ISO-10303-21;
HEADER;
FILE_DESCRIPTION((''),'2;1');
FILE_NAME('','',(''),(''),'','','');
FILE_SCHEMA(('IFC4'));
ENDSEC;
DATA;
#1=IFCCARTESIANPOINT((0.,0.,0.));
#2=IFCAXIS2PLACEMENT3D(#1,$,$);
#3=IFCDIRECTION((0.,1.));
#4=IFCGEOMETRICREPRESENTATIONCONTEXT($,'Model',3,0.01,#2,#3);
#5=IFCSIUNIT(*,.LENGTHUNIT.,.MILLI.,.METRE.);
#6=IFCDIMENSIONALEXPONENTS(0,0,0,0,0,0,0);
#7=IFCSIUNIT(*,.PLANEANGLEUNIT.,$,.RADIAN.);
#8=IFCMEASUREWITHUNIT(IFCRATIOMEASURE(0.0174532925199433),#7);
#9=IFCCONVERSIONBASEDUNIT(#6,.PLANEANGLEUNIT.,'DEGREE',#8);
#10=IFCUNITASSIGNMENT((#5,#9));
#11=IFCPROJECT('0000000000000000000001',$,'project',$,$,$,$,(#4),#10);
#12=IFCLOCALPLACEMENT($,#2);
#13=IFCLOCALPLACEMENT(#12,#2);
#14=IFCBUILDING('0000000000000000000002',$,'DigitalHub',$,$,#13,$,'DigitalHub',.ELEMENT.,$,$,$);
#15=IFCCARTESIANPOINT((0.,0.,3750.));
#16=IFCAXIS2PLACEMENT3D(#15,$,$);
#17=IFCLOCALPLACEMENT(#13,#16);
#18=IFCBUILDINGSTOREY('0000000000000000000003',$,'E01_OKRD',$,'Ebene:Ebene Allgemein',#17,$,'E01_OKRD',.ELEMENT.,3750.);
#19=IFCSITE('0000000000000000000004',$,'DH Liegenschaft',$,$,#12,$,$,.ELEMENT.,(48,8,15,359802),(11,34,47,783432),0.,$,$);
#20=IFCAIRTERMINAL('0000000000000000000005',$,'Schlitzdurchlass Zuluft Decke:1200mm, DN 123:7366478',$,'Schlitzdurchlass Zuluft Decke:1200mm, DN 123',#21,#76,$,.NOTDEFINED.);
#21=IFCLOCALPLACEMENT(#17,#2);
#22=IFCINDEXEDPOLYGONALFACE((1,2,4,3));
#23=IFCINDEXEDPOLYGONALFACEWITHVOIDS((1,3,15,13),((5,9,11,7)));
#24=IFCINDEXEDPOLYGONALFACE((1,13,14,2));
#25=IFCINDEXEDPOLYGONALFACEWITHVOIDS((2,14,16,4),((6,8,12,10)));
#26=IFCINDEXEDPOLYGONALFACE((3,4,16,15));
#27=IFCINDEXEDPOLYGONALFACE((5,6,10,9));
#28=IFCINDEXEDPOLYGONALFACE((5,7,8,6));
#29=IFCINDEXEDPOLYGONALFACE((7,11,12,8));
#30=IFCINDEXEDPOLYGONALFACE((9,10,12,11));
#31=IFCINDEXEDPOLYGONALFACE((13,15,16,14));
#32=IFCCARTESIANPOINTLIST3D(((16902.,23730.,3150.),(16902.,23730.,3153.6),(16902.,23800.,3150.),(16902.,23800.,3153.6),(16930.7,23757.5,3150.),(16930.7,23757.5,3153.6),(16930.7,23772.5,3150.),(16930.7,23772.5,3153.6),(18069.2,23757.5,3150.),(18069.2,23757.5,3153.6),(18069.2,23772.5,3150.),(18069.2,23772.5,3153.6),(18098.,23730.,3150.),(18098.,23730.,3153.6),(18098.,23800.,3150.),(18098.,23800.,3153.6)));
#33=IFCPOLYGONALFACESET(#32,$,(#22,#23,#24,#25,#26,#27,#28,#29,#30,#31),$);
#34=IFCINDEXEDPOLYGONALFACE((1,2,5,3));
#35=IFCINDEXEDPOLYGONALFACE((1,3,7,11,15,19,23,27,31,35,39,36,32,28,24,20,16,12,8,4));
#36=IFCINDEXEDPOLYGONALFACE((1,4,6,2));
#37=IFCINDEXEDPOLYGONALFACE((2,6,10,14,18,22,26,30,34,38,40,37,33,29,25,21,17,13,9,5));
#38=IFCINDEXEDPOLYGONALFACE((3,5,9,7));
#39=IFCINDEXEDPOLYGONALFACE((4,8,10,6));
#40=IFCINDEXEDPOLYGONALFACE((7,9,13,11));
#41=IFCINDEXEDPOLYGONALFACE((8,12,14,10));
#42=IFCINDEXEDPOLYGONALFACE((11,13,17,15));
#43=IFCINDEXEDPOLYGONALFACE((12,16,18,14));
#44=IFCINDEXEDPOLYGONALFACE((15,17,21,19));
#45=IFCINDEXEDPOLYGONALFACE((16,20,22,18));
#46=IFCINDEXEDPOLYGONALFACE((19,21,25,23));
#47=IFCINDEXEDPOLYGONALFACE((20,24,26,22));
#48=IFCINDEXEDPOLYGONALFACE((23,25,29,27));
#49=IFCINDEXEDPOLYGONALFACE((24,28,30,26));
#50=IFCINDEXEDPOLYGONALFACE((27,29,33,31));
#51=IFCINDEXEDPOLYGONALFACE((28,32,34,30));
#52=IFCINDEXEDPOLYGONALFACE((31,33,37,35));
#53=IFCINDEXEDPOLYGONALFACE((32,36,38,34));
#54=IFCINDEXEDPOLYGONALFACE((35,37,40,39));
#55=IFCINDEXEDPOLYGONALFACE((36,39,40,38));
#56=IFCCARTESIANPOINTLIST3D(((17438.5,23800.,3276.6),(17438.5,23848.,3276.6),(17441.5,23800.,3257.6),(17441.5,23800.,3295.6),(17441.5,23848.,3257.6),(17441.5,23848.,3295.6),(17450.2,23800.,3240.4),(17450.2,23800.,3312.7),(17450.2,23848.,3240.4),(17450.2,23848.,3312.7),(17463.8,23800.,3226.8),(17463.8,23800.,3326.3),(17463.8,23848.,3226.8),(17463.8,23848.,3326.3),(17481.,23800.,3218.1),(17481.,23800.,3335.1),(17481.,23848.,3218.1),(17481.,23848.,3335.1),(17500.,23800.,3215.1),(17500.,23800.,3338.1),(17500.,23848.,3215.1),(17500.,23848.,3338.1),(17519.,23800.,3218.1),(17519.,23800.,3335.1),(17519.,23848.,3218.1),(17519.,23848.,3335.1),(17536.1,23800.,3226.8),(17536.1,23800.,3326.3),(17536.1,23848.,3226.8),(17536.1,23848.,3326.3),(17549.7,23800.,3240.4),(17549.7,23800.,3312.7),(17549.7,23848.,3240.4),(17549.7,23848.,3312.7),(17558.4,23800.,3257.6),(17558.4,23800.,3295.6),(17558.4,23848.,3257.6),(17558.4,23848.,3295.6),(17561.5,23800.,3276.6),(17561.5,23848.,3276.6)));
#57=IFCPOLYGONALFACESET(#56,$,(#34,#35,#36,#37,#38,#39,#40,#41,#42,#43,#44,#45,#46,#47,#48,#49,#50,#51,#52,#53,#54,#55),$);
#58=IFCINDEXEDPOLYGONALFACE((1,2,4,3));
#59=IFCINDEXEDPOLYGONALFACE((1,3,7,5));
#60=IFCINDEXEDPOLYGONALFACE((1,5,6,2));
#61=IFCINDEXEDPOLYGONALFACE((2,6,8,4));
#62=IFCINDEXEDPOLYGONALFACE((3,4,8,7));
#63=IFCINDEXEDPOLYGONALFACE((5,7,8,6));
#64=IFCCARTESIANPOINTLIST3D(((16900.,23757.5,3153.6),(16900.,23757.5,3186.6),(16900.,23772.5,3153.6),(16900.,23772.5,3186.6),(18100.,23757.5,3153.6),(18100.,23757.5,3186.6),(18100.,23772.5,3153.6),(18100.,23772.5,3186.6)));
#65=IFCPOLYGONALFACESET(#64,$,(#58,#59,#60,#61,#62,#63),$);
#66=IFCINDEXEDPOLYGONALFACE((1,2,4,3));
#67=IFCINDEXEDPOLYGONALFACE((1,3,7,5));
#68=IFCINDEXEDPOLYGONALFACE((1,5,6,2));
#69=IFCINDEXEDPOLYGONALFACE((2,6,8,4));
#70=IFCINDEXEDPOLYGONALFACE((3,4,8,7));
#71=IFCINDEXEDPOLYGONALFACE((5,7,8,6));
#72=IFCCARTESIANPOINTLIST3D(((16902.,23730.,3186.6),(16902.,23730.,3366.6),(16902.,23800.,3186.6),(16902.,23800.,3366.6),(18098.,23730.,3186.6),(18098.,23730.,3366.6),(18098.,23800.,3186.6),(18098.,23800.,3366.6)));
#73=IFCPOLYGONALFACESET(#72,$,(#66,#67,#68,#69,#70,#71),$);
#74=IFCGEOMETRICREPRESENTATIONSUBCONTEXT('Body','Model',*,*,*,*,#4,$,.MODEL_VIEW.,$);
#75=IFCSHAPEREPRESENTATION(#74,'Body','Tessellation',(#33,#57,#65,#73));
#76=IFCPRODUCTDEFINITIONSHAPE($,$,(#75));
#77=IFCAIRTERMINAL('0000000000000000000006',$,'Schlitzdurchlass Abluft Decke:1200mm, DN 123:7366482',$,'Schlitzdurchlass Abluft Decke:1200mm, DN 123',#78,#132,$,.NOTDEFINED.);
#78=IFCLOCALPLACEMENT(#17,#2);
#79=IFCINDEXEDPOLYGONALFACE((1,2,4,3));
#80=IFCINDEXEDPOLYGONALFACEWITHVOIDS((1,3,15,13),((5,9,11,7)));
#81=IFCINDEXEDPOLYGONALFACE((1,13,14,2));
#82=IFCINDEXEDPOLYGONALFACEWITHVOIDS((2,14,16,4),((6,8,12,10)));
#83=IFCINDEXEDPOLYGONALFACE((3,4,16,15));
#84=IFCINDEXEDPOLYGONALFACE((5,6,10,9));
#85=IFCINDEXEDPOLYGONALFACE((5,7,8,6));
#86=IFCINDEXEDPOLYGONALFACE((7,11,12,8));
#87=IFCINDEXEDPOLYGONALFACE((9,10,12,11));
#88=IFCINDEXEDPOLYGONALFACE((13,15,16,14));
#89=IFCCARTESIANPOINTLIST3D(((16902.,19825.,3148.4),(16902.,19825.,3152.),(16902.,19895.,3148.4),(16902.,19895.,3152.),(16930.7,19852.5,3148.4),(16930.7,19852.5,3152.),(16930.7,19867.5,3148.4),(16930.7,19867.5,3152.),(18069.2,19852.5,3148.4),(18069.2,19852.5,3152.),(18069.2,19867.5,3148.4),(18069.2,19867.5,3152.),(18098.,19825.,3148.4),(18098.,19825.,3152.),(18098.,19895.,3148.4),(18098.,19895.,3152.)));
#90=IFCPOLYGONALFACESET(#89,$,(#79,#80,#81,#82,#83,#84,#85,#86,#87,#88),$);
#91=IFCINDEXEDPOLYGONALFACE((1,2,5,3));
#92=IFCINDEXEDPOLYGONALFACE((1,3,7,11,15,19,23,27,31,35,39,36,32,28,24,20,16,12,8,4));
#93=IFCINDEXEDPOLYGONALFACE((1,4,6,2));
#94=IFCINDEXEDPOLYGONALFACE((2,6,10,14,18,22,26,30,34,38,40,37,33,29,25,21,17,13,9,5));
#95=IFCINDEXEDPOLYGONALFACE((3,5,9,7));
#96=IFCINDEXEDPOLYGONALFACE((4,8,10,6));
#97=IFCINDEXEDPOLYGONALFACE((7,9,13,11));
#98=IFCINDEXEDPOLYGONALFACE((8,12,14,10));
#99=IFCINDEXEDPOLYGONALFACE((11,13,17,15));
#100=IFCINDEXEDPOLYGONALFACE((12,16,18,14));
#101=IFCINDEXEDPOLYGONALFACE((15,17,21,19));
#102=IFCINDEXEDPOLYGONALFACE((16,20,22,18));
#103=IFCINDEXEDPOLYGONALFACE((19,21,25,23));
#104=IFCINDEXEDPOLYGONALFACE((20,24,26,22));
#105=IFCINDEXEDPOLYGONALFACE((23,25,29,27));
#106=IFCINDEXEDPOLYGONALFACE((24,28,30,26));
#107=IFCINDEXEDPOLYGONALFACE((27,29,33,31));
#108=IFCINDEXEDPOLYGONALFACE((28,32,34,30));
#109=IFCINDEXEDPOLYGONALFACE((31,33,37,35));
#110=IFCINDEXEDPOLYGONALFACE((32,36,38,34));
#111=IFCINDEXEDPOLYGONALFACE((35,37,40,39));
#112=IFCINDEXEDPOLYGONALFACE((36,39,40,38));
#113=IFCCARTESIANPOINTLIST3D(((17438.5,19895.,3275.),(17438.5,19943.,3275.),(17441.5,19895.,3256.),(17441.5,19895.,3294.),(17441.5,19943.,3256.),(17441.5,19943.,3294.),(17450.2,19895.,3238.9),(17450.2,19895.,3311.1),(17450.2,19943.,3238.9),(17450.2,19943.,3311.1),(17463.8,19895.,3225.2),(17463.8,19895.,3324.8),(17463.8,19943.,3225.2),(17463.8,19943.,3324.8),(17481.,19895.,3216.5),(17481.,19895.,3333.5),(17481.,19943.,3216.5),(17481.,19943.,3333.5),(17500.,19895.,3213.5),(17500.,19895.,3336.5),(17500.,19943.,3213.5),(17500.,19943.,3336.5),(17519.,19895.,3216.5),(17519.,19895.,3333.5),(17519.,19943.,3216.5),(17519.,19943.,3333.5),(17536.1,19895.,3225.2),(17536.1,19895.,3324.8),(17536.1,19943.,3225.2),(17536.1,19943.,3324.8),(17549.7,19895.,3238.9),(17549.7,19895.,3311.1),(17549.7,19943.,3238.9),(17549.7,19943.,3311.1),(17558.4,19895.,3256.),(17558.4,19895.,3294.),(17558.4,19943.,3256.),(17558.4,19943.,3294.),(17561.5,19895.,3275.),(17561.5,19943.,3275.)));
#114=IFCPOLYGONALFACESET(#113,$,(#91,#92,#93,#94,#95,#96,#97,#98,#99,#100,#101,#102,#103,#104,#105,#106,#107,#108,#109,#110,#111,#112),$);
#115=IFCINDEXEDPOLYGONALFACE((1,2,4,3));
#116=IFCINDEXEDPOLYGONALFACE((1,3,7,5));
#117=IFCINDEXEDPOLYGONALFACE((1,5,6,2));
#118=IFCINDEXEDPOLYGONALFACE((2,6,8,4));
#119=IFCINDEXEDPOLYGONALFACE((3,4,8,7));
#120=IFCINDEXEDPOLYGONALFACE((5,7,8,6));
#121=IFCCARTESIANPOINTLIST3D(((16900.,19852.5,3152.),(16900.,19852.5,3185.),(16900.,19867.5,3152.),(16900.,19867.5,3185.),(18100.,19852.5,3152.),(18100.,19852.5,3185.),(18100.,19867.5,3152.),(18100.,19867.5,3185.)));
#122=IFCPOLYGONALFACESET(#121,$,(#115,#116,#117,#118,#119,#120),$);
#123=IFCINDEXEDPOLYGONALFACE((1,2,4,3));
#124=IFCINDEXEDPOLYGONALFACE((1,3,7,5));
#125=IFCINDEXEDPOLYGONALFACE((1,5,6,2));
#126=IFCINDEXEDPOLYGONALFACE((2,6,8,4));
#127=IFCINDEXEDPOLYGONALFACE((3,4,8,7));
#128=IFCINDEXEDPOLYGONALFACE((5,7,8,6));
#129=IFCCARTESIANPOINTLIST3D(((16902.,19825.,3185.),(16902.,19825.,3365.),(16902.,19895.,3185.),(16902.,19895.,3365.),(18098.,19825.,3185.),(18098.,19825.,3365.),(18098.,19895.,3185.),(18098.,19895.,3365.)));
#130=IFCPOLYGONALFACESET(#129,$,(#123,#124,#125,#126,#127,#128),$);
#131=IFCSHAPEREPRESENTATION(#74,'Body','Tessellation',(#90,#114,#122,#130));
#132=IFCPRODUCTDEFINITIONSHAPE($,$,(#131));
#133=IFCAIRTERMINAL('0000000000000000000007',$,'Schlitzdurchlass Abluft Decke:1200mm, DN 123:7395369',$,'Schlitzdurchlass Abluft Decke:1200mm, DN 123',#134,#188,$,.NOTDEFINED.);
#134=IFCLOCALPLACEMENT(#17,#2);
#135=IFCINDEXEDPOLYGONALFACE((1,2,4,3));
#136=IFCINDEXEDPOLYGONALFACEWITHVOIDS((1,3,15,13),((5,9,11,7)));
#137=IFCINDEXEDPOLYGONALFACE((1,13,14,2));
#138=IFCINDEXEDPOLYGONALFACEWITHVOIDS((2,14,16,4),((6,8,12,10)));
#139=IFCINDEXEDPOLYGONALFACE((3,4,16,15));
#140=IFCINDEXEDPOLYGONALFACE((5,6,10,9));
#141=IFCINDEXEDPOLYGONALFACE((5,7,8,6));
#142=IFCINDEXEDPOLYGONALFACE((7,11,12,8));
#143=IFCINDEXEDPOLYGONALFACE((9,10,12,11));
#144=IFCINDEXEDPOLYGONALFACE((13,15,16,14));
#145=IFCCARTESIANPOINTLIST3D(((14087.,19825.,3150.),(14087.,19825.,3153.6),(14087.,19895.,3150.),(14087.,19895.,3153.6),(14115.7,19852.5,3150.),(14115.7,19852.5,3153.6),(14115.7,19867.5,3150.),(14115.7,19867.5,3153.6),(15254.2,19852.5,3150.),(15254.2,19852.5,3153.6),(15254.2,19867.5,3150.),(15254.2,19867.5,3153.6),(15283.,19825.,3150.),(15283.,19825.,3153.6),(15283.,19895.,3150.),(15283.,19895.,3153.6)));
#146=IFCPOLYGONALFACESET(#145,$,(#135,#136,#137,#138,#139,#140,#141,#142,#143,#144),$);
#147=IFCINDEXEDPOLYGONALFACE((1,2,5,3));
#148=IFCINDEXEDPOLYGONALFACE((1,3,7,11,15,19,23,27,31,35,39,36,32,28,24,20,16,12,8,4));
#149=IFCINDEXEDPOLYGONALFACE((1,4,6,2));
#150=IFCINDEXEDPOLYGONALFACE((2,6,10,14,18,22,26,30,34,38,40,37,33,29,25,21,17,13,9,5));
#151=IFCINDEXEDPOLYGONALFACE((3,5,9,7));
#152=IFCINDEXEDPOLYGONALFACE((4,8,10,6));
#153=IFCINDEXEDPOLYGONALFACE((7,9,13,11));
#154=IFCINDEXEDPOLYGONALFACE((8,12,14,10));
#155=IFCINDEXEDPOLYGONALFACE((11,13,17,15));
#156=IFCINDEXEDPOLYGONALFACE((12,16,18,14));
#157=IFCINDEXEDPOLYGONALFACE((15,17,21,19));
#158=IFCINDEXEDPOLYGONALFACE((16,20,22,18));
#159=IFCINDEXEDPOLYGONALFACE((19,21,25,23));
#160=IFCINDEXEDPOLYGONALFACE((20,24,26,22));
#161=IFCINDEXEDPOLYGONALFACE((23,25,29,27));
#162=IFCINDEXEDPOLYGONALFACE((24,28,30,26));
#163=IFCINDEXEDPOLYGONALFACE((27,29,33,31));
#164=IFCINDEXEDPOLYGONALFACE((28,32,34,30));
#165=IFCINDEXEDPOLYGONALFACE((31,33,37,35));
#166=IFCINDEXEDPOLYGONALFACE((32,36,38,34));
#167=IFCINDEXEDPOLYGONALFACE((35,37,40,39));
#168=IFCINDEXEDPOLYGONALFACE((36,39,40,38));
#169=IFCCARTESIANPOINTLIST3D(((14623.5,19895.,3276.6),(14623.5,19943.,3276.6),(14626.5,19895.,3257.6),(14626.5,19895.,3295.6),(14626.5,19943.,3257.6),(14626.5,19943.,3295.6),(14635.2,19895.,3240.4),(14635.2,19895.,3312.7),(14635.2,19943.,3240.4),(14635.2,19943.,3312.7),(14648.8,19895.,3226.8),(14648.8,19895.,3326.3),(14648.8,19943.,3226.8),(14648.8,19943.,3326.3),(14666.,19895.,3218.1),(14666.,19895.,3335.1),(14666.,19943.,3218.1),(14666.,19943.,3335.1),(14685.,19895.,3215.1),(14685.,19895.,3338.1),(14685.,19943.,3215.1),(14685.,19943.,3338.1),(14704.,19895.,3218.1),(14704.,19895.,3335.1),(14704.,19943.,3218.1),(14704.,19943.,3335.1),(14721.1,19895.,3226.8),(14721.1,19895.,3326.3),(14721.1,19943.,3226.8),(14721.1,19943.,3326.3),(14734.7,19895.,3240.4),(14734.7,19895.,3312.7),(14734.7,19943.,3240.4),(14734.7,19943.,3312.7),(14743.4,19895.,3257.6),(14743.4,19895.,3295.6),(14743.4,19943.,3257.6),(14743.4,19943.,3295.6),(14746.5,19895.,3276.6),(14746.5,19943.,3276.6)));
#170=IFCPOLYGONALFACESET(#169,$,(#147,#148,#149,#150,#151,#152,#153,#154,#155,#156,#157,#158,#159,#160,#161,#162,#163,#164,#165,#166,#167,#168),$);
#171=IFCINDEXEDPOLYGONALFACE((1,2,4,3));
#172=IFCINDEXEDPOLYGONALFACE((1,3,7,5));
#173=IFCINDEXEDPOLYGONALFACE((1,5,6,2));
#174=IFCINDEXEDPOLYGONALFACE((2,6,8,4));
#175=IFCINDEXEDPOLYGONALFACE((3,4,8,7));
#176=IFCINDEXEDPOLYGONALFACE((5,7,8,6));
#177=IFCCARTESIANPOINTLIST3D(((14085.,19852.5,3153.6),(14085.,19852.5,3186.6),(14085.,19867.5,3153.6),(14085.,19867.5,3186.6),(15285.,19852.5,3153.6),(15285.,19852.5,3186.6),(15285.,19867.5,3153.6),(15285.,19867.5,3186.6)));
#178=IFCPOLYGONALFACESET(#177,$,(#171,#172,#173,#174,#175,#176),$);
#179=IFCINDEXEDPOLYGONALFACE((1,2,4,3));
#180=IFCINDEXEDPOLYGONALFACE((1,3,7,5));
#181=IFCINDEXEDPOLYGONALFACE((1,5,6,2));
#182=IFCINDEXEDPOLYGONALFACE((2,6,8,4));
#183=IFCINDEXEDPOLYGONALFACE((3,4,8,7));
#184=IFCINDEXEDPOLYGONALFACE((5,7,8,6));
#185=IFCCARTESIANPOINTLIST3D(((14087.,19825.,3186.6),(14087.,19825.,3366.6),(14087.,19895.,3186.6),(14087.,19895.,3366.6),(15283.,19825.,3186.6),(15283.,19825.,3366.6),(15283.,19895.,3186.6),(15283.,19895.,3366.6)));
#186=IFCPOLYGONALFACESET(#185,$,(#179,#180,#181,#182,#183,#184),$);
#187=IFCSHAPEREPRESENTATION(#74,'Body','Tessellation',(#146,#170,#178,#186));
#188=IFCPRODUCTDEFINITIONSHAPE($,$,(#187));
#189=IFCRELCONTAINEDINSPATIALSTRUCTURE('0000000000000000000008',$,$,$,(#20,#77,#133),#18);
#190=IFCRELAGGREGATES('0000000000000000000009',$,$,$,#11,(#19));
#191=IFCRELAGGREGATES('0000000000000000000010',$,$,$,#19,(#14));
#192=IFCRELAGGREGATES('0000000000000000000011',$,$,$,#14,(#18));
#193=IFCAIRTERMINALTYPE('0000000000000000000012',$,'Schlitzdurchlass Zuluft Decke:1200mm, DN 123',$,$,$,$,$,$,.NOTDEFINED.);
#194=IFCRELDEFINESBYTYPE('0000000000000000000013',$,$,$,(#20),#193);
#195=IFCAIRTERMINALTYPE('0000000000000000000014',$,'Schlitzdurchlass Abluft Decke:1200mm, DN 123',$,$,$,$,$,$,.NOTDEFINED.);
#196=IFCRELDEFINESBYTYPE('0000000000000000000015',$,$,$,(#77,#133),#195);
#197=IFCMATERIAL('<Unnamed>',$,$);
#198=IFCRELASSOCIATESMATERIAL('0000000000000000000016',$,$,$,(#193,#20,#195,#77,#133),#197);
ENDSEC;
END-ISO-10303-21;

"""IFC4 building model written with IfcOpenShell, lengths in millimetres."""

from ifc_helpers import new_model, entity, si_unit, converted_unit, direction, frame, origin, place, context, subcontext, project, spatial, indexed_curve, outline, extrude, source, transform, mapped, material, type_object, type_shapes, element, save


model = new_model("IFC4")

# Units and contexts
model_context = context("Model", 3, precision=0.01, world=origin(), true_north=direction((0.0, 1.0)))
body_context = subcontext(model_context, "Body", "Model", "MODEL_VIEW")
ifc_project = project(units=[si_unit("LENGTHUNIT", "METRE", prefix="MILLI"), converted_unit("PLANEANGLEUNIT", "DEGREE", entity("IfcRatioMeasure", 0.0174532925199433), si_unit("PLANEANGLEUNIT", "RADIAN"), dimensions=[0, 0, 0, 0, 0, 0, 0])], contexts=[model_context])

# Site, building, storey
site_placement = place(None, origin())
site = spatial("IfcSite", under=ifc_project, at=site_placement, Name="DH Liegenschaft", CompositionType="ELEMENT", RefLatitude=(48, 8, 15, 359802), RefLongitude=(11, 34, 47, 783432), RefElevation=0.0)
building_placement = place(site_placement, origin())
building = spatial("IfcBuilding", under=site, at=building_placement, Name="DigitalHub", LongName="DigitalHub", CompositionType="ELEMENT")
storey_placement = place(building_placement, frame((0.0, 0.0, 3750.0)))
storey = spatial("IfcBuildingStorey", under=building, at=storey_placement, Name="E01_OKRD", ObjectType="Ebene:Ebene Allgemein", LongName="E01_OKRD", CompositionType="ELEMENT", Elevation=3750.0)

# Air terminals
ifc_material_1 = material(Name="<Unnamed>")
air_terminal_type_1 = type_object("IfcAirTerminalType", Name="Schlitzdurchlass Zuluft Decke:1200mm, DN 123", PredefinedType="NOTDEFINED", material=ifc_material_1)
shared_shape_1 = source(origin(), body_context, "Body", "SweptSolid", [
    extrude(outline(indexed_curve([(-598.0, -35.0), (598.0, -35.0), (598.0, 35.0), (-598.0, 35.0), (-598.0, -35.0)], self_intersect=False), holes=[indexed_curve([(-569.2, -7.5), (-569.2, 7.5), (569.2, 7.5), (569.2, -7.5), (-569.2, -7.5)], self_intersect=False)]), frame((600.0, 35.0, 0.0), z_axis=(0.0, 0.0, 1.0), x_axis=(-1.0, 0.0, 0.0)), (0.0, 0.0, 1.0), 3.6),
    extrude(outline(indexed_curve([(61.5, 0.0), (58.5, 19.0), (49.8, 36.1), (36.1, 49.8), (19.0, 58.5), (0.0, 61.5), (-19.0, 58.5), (-36.1, 49.8), (-49.8, 36.1), (-58.5, 19.0), (-61.5, 0.0), (-58.5, -19.0), (-49.8, -36.1), (-36.1, -49.8), (-19.0, -58.5), (0.0, -61.5), (19.0, -58.5), (36.1, -49.8), (49.8, -36.1), (58.5, -19.0), (61.5, 0.0)], self_intersect=False)), frame((600.0, 70.0, 126.6), z_axis=(0.0, 1.0, 0.0), x_axis=(-1.0, 0.0, 0.0)), (0.0, 0.0, 1.0), 48.0),
    extrude(outline(indexed_curve([(-600.0, -7.5), (600.0, -7.5), (600.0, 7.5), (-600.0, 7.5), (-600.0, -7.5)], self_intersect=False)), frame((600.0, 35.0, 3.6), z_axis=(0.0, 0.0, 1.0), x_axis=(-1.0, 0.0, 0.0)), (0.0, 0.0, 1.0), 33.0),
    extrude(outline(indexed_curve([(-598.0, -35.0), (598.0, -35.0), (598.0, 35.0), (-598.0, 35.0), (-598.0, -35.0)], self_intersect=False)), frame((600.0, 35.0, 36.6), z_axis=(0.0, 0.0, 1.0), x_axis=(-1.0, 0.0, 0.0)), (0.0, 0.0, 1.0), 180.0),
])
type_shapes(air_terminal_type_1, [shared_shape_1])
air_terminal_placement = place(storey_placement, frame((16900.0, 23730.0, 3150.0)))
element("IfcAirTerminal", 1, at=air_terminal_placement, inside=storey, type_object=air_terminal_type_1, material=ifc_material_1, Name="Schlitzdurchlass Zuluft Decke:1200mm, DN 123:7366478", ObjectType="Schlitzdurchlass Zuluft Decke:1200mm, DN 123", PredefinedType="NOTDEFINED", context=body_context, shape_type="MappedRepresentation", body=[
    mapped(shared_shape_1, transform((0.0, 0.0, 0.0), scale=1.0)),
])
air_terminal_type_2 = type_object("IfcAirTerminalType", Name="Schlitzdurchlass Abluft Decke:1200mm, DN 123", PredefinedType="NOTDEFINED", material=ifc_material_1)
shared_shape_2 = source(origin(), body_context, "Body", "SweptSolid", [
    extrude(outline(indexed_curve([(-598.0, -35.0), (598.0, -35.0), (598.0, 35.0), (-598.0, 35.0), (-598.0, -35.0)], self_intersect=False), holes=[indexed_curve([(-569.2, -7.5), (-569.2, 7.5), (569.2, 7.5), (569.2, -7.5), (-569.2, -7.5)], self_intersect=False)]), frame((0.0, 0.0, 0.0), z_axis=(0.0, 0.0, 1.0), x_axis=(-1.0, 0.0, 0.0)), (0.0, 0.0, 1.0), 3.6),
    extrude(outline(indexed_curve([(61.5, 0.0), (58.5, 19.0), (49.8, 36.1), (36.1, 49.8), (19.0, 58.5), (0.0, 61.5), (-19.0, 58.5), (-36.1, 49.8), (-49.8, 36.1), (-58.5, 19.0), (-61.5, 0.0), (-58.5, -19.0), (-49.8, -36.1), (-36.1, -49.8), (-19.0, -58.5), (0.0, -61.5), (19.0, -58.5), (36.1, -49.8), (49.8, -36.1), (58.5, -19.0), (61.5, 0.0)], self_intersect=False)), frame((0.0, 35.0, 126.6), z_axis=(0.0, 1.0, 0.0), x_axis=(-1.0, 0.0, 0.0)), (0.0, 0.0, 1.0), 48.0),
    extrude(outline(indexed_curve([(-600.0, -7.5), (600.0, -7.5), (600.0, 7.5), (-600.0, 7.5), (-600.0, -7.5)], self_intersect=False)), frame((0.0, 0.0, 3.6), z_axis=(0.0, 0.0, 1.0), x_axis=(-1.0, 0.0, 0.0)), (0.0, 0.0, 1.0), 33.0),
    extrude(outline(indexed_curve([(-598.0, -35.0), (598.0, -35.0), (598.0, 35.0), (-598.0, 35.0), (-598.0, -35.0)], self_intersect=False)), frame((0.0, 0.0, 36.6), z_axis=(0.0, 0.0, 1.0), x_axis=(-1.0, 0.0, 0.0)), (0.0, 0.0, 1.0), 180.0),
])
type_shapes(air_terminal_type_2, [shared_shape_2])
for number, where, name in (
    (2, (17500.0, 19860.0, 3148.4), "Schlitzdurchlass Abluft Decke:1200mm, DN 123:7366482"),
    (3, (14685.0, 19860.0, 3150.0), "Schlitzdurchlass Abluft Decke:1200mm, DN 123:7395369"),
):
    element("IfcAirTerminal", number, at=place(storey_placement, frame(where)), inside=storey, type_object=air_terminal_type_2, material=ifc_material_1, Name=name, ObjectType="Schlitzdurchlass Abluft Decke:1200mm, DN 123", PredefinedType="NOTDEFINED", context=body_context, shape_type="MappedRepresentation", body=[
        mapped(shared_shape_2, transform((0.0, 0.0, 0.0), scale=1.0)),
    ])

save(model, "model.ifc")
